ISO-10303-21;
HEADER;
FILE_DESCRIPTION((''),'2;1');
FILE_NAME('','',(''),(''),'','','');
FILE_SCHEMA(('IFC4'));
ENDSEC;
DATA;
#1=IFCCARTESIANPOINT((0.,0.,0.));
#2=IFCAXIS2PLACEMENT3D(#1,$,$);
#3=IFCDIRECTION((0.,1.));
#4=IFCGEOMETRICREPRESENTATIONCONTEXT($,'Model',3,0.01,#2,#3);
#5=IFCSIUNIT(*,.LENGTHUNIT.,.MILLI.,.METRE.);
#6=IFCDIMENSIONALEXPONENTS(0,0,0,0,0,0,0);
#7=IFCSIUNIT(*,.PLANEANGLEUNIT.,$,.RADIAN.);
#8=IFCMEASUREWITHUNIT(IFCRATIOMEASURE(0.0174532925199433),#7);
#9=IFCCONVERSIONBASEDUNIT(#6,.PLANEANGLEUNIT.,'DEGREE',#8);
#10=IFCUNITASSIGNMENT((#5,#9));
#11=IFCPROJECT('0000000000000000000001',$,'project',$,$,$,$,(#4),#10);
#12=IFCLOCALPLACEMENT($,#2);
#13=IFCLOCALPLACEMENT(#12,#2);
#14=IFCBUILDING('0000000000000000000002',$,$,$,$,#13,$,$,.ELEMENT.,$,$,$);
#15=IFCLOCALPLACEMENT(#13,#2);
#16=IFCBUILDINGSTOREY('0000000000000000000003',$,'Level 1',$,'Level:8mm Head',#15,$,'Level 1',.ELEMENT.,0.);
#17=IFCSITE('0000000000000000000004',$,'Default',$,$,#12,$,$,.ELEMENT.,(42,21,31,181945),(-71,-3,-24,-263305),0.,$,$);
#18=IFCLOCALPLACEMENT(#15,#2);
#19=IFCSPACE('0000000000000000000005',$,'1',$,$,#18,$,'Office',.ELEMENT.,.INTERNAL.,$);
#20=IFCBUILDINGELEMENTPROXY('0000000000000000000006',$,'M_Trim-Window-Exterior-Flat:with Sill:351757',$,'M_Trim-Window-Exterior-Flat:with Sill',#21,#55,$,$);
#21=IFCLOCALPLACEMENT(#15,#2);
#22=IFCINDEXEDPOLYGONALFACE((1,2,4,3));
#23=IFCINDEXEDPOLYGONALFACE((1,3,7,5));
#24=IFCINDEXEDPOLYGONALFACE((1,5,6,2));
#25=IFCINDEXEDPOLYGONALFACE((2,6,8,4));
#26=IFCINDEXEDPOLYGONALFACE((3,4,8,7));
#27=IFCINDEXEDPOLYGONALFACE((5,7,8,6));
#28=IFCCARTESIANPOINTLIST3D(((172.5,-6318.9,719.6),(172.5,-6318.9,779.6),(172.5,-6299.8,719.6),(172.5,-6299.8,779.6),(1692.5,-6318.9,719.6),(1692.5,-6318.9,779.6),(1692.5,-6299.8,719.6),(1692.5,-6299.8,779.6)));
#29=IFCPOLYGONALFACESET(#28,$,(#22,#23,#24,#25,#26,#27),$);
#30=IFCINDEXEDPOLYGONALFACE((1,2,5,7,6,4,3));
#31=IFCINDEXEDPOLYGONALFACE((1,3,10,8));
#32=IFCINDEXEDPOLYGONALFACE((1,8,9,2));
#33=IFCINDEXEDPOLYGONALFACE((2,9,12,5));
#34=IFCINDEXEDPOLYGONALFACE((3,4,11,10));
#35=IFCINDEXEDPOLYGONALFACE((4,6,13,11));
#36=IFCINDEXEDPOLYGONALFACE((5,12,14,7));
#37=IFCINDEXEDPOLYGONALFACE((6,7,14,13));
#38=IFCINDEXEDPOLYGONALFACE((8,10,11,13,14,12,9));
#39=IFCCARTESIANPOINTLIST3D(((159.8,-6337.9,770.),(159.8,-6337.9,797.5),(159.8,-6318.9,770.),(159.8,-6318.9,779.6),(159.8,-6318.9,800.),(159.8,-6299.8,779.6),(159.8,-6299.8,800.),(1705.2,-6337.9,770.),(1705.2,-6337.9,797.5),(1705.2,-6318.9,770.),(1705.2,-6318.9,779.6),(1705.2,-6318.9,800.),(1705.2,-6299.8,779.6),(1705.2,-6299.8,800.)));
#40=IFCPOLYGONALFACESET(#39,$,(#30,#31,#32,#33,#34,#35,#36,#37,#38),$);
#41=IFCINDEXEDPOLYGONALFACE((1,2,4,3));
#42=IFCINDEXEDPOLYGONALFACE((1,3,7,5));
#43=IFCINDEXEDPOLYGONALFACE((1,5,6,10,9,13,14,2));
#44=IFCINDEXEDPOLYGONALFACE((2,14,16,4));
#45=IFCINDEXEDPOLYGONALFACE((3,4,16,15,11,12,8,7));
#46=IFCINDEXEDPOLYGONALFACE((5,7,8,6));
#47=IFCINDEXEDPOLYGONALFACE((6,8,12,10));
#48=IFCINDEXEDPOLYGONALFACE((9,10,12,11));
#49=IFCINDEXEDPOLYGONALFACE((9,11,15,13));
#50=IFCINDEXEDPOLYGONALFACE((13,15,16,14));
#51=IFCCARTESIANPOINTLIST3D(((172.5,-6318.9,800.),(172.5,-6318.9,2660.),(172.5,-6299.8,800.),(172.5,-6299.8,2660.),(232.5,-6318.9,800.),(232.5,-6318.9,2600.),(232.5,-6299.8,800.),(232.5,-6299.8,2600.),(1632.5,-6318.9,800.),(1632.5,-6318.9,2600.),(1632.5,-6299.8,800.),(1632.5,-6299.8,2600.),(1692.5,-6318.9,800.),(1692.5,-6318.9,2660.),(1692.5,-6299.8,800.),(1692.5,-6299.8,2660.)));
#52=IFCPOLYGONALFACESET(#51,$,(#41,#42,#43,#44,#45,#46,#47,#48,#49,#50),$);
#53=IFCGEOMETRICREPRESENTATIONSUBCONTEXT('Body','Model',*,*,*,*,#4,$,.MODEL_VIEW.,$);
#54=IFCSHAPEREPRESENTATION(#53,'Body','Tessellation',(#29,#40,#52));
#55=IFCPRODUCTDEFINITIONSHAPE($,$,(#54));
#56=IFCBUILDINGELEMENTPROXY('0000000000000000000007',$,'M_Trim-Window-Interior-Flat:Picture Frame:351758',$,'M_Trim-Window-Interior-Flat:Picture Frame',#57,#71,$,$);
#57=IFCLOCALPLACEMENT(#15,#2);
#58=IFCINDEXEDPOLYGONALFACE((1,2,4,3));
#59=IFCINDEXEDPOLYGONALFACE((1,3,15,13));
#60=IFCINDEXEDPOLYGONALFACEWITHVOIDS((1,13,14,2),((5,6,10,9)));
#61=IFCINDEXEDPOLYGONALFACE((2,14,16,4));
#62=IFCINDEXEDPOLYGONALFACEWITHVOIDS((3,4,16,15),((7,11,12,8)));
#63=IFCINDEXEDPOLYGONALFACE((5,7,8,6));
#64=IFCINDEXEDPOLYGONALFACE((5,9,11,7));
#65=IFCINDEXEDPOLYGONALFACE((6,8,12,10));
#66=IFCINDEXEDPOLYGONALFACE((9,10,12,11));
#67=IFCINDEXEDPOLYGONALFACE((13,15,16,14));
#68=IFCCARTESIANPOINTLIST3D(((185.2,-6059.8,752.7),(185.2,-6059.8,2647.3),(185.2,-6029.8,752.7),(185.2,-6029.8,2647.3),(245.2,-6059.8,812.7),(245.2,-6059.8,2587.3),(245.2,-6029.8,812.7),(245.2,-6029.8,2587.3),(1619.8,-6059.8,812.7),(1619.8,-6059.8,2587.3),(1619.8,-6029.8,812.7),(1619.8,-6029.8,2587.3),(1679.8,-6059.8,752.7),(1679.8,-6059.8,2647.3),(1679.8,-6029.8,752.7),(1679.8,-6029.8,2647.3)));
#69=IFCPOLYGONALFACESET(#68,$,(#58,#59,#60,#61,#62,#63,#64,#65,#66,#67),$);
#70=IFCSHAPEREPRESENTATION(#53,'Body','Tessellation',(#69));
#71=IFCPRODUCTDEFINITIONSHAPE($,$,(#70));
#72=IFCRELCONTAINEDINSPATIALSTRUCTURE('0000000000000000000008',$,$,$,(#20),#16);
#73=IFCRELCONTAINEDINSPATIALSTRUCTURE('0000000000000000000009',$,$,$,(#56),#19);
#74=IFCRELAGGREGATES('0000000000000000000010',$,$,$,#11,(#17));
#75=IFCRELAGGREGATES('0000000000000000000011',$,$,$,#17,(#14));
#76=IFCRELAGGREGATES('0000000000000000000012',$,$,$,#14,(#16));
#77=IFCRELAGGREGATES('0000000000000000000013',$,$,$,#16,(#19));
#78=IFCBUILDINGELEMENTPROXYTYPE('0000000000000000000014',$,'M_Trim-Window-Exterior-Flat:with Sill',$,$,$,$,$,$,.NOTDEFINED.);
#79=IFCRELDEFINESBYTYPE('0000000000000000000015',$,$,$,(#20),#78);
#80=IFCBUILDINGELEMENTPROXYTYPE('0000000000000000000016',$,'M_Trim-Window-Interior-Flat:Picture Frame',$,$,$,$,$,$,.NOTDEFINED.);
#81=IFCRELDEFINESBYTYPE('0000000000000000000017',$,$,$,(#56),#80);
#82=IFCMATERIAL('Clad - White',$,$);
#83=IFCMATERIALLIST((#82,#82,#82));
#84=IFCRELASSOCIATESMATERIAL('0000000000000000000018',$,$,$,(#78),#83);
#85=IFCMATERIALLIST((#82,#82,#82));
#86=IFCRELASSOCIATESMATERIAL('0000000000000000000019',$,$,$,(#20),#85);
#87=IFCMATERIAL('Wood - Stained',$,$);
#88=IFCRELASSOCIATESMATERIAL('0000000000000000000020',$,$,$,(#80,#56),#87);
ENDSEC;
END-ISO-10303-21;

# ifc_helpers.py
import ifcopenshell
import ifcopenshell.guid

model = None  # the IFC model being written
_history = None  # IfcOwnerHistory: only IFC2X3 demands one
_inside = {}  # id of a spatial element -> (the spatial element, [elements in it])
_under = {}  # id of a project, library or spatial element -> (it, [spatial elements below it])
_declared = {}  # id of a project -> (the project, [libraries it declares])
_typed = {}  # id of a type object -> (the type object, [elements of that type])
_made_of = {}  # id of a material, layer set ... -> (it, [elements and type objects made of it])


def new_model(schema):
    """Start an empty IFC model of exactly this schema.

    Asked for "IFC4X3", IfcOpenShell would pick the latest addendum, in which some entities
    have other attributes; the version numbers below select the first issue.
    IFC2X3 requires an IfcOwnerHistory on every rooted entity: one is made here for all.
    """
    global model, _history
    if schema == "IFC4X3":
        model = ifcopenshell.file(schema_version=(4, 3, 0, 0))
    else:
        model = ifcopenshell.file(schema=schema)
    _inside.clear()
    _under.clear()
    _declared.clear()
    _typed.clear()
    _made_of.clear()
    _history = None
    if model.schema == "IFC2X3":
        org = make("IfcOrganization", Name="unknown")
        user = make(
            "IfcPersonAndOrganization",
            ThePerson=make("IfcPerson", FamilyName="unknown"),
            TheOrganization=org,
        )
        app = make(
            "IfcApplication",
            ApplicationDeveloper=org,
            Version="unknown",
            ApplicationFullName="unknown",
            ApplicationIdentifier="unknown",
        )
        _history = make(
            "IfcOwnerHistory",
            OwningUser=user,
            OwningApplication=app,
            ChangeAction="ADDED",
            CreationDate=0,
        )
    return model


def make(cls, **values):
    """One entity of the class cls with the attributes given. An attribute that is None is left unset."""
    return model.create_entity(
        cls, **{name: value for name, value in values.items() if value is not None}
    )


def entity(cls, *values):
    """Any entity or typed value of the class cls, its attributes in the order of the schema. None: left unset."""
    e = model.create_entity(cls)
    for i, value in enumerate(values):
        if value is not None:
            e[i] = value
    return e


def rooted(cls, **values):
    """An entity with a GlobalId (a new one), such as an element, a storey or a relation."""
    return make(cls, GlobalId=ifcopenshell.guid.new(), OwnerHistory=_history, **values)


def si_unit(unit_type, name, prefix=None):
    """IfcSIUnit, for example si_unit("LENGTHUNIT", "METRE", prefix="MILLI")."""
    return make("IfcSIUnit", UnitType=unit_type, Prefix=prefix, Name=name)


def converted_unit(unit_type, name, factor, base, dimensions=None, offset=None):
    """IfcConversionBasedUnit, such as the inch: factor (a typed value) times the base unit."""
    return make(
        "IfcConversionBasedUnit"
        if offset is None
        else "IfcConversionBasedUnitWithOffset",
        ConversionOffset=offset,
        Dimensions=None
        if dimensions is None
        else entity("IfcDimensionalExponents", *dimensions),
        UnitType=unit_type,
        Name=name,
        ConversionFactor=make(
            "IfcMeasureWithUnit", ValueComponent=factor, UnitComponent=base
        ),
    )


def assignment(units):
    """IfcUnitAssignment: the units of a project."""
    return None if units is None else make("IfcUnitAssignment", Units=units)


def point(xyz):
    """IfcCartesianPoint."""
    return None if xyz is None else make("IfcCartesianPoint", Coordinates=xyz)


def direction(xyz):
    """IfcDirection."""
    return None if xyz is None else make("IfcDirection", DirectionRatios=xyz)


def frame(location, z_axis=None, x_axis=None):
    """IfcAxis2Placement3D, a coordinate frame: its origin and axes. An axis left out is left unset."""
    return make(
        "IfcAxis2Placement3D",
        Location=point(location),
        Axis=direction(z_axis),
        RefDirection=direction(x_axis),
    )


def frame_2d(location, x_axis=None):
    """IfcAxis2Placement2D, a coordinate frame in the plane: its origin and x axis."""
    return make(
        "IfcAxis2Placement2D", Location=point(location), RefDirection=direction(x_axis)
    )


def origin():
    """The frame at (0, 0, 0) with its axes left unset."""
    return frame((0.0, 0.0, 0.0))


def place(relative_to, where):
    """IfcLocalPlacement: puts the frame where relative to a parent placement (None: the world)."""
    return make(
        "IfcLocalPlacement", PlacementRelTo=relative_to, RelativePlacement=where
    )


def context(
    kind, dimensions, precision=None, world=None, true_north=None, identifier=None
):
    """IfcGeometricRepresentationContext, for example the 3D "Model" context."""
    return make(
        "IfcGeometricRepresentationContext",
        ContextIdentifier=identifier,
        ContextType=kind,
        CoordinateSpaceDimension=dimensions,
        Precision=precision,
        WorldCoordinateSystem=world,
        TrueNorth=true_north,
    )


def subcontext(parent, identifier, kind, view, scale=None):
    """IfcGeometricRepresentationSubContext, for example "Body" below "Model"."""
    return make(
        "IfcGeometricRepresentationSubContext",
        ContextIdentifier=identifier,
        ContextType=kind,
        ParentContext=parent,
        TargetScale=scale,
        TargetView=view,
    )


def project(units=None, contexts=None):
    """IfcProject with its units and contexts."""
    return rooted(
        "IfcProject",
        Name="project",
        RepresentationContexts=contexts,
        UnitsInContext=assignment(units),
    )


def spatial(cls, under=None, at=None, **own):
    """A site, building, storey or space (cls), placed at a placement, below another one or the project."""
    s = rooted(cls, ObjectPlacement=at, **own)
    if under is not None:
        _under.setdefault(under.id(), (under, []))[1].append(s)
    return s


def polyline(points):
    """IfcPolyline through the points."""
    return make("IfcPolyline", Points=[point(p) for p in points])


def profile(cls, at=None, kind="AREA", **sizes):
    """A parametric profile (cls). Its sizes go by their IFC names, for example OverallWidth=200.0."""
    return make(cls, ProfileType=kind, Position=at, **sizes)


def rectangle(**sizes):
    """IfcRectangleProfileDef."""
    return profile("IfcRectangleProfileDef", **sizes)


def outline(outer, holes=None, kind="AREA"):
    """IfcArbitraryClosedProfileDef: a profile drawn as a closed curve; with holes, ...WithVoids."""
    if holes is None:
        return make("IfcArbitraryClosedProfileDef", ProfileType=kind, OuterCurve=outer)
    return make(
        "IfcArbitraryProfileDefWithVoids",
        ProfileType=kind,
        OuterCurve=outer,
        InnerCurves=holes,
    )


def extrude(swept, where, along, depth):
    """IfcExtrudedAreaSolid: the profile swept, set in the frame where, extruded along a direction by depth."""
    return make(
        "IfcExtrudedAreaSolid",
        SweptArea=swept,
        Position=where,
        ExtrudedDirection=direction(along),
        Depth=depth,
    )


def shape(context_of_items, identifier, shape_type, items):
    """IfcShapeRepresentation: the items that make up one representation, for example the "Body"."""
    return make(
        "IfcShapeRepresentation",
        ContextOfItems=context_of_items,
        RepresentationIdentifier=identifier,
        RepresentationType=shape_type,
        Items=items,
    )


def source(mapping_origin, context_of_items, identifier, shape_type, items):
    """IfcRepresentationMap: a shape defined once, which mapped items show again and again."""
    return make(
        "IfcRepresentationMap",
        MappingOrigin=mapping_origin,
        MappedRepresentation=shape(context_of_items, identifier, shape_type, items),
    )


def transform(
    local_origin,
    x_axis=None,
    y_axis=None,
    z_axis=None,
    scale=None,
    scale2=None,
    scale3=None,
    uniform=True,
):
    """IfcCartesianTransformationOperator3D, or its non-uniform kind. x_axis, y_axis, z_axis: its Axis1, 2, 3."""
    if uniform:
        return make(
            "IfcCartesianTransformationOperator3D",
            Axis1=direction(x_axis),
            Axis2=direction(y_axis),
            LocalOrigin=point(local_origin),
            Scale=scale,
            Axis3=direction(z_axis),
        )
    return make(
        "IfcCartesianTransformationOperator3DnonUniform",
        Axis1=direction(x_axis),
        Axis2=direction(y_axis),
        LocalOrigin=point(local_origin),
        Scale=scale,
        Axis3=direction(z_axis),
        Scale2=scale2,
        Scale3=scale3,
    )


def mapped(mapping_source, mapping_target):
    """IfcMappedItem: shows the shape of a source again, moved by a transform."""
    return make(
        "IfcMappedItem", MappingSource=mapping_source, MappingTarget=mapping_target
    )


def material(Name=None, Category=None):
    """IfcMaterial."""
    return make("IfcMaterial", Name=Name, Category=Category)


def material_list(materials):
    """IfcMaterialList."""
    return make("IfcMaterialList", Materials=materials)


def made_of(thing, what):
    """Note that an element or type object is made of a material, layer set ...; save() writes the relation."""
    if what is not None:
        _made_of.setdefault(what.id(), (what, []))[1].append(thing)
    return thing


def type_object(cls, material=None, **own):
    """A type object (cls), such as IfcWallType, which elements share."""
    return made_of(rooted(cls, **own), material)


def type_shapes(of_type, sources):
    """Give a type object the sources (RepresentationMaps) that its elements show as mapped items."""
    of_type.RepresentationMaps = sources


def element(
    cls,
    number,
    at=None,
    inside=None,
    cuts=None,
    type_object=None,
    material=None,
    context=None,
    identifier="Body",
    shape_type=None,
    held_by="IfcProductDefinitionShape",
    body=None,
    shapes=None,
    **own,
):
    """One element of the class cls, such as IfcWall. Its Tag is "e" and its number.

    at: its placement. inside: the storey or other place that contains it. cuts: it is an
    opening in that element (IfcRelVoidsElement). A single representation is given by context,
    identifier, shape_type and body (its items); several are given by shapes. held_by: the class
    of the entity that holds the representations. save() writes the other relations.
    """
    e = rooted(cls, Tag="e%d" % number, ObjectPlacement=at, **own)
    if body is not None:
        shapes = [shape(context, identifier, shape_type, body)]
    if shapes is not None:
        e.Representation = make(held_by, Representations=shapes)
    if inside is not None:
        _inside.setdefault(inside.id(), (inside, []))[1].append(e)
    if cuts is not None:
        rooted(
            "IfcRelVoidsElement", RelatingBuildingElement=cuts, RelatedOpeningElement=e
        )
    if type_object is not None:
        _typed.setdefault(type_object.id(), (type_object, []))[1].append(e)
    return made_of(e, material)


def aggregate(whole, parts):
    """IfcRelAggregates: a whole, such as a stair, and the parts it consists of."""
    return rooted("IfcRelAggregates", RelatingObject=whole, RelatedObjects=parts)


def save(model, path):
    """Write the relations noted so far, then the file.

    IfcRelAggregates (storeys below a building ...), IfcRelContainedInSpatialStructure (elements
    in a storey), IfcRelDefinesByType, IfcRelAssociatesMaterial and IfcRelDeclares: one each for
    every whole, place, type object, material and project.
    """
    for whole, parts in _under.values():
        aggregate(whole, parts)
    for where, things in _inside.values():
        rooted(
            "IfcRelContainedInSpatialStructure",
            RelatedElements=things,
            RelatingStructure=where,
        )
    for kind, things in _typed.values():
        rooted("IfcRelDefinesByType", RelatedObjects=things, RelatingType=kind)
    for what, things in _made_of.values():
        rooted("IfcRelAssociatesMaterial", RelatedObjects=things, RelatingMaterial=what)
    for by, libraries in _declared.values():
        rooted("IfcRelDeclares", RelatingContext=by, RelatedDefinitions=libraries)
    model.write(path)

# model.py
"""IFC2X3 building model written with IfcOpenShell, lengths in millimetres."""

from ifc_helpers import new_model, entity, si_unit, converted_unit, direction, frame, frame_2d, origin, place, context, subcontext, project, spatial, polyline, rectangle, outline, extrude, source, transform, mapped, material, material_list, type_object, type_shapes, element, save


model = new_model("IFC2X3")

# Units and contexts
model_context = context("Model", 3, precision=0.01, world=origin(), true_north=direction((0.0, 1.0)))
body_context = subcontext(model_context, "Body", "Model", "MODEL_VIEW")
ifc_project = project(units=[si_unit("LENGTHUNIT", "METRE", prefix="MILLI"), converted_unit("PLANEANGLEUNIT", "DEGREE", entity("IfcRatioMeasure", 0.0174532925199433), si_unit("PLANEANGLEUNIT", "RADIAN"), dimensions=[0, 0, 0, 0, 0, 0, 0])], contexts=[model_context])

# Site, building, storey
site_placement = place(None, origin())
site = spatial("IfcSite", under=ifc_project, at=site_placement, Name="Default", CompositionType="ELEMENT", RefLatitude=(42, 21, 31, 181945), RefLongitude=(-71, -3, -24, -263305), RefElevation=0.0)
building_placement = place(site_placement, origin())
building = spatial("IfcBuilding", under=site, at=building_placement, CompositionType="ELEMENT")
storey_placement = place(building_placement, origin())
storey = spatial("IfcBuildingStorey", under=building, at=storey_placement, Name="Level 1", ObjectType="Level:8mm Head", LongName="Level 1", CompositionType="ELEMENT", Elevation=0.0)

# Building element proxy
ifc_material_1 = material(Name="Clad - White")
ifc_material_2 = material(Name="Wood - Stained")
ifc_material_list_1 = material_list([ifc_material_1, ifc_material_1, ifc_material_1])
ifc_material_list_2 = material_list([ifc_material_1, ifc_material_1, ifc_material_1])
building_element_proxy_type_1 = type_object("IfcBuildingElementProxyType", Name="M_Trim-Window-Exterior-Flat:with Sill", PredefinedType="NOTDEFINED", material=ifc_material_list_2)
shared_shape_1 = source(origin(), body_context, "Body", "SweptSolid", [
    extrude(rectangle(XDim=1520.0, YDim=60.0, at=frame_2d((0.0, 0.0), x_axis=(1.0, 0.0))), frame((0.0, -1850.4, 0.0), z_axis=(0.0, 0.0, 1.0), x_axis=(-1.0, 0.0, 0.0)), (0.0, 0.0, 1.0), 19.1),
    extrude(outline(polyline([(-19.0, -15.2), (0.0, -15.2), (0.0, -5.7), (19.0, -5.7), (19.0, 14.8), (0.0, 14.8), (-19.0, 12.3), (-19.0, -15.2)])), frame((-772.7, -1814.8, 19.0), z_axis=(1.0, 0.0, 0.0), x_axis=(0.0, 0.0, -1.0)), (0.0, 0.0, 1.0), 1545.4),
    extrude(outline(polyline([(-945.0, -760.0), (915.0, -760.0), (915.0, -700.0), (-885.0, -700.0), (-885.0, 700.0), (915.0, 700.0), (915.0, 760.0), (-945.0, 760.0), (-945.0, -760.0)])), frame((0.0, -885.0, 0.0), z_axis=(0.0, 0.0, 1.0), x_axis=(0.0, -1.0, 0.0)), (0.0, 0.0, 1.0), 19.1),
])
type_shapes(building_element_proxy_type_1, [shared_shape_1])
proxy_1_placement = place(storey_placement, frame((932.5, -6299.8, 2600.0), z_axis=(0.0, -1.0, 0.0), x_axis=(1.0, 0.0, 0.0)))
element("IfcBuildingElementProxy", 1, at=proxy_1_placement, inside=storey, type_object=building_element_proxy_type_1, material=ifc_material_list_1, Name="M_Trim-Window-Exterior-Flat:with Sill:351757", ObjectType="M_Trim-Window-Exterior-Flat:with Sill", context=body_context, shape_type="MappedRepresentation", body=[
    mapped(shared_shape_1, transform((0.0, 0.0, 0.0), scale=1.0)),
])

# Shared definitions
space_placement = place(storey_placement, origin())
space = spatial("IfcSpace", under=storey, at=space_placement, Name="1", LongName="Office", CompositionType="ELEMENT", InteriorOrExteriorSpace="INTERNAL")

# Building element proxy
building_element_proxy_type_2 = type_object("IfcBuildingElementProxyType", Name="M_Trim-Window-Interior-Flat:Picture Frame", PredefinedType="NOTDEFINED", material=ifc_material_2)
shared_shape_2 = source(origin(), body_context, "Body", "SweptSolid", [
    extrude(outline(polyline([(-747.3, -947.3), (747.3, -947.3), (747.3, 947.3), (-747.3, 947.3), (-747.3, -947.3)]), holes=[polyline([(-687.3, -887.3), (-687.3, 887.3), (687.3, 887.3), (687.3, -887.3), (-687.3, -887.3)])]), frame((0.0, -900.0, 0.0), z_axis=(0.0, 0.0, 1.0), x_axis=(-1.0, 0.0, 0.0)), (0.0, 0.0, 1.0), 30.0),
])
type_shapes(building_element_proxy_type_2, [shared_shape_2])
proxy_2_placement = place(space_placement, frame((932.5, -6059.8, 2600.0), z_axis=(0.0, 1.0, 0.0), x_axis=(-1.0, 0.0, 0.0)))
element("IfcBuildingElementProxy", 2, at=proxy_2_placement, inside=space, type_object=building_element_proxy_type_2, material=ifc_material_2, Name="M_Trim-Window-Interior-Flat:Picture Frame:351758", ObjectType="M_Trim-Window-Interior-Flat:Picture Frame", context=body_context, shape_type="MappedRepresentation", body=[
    mapped(shared_shape_2, transform((0.0, 0.0, 0.0), scale=1.0)),
])

save(model, "model.ifc")
